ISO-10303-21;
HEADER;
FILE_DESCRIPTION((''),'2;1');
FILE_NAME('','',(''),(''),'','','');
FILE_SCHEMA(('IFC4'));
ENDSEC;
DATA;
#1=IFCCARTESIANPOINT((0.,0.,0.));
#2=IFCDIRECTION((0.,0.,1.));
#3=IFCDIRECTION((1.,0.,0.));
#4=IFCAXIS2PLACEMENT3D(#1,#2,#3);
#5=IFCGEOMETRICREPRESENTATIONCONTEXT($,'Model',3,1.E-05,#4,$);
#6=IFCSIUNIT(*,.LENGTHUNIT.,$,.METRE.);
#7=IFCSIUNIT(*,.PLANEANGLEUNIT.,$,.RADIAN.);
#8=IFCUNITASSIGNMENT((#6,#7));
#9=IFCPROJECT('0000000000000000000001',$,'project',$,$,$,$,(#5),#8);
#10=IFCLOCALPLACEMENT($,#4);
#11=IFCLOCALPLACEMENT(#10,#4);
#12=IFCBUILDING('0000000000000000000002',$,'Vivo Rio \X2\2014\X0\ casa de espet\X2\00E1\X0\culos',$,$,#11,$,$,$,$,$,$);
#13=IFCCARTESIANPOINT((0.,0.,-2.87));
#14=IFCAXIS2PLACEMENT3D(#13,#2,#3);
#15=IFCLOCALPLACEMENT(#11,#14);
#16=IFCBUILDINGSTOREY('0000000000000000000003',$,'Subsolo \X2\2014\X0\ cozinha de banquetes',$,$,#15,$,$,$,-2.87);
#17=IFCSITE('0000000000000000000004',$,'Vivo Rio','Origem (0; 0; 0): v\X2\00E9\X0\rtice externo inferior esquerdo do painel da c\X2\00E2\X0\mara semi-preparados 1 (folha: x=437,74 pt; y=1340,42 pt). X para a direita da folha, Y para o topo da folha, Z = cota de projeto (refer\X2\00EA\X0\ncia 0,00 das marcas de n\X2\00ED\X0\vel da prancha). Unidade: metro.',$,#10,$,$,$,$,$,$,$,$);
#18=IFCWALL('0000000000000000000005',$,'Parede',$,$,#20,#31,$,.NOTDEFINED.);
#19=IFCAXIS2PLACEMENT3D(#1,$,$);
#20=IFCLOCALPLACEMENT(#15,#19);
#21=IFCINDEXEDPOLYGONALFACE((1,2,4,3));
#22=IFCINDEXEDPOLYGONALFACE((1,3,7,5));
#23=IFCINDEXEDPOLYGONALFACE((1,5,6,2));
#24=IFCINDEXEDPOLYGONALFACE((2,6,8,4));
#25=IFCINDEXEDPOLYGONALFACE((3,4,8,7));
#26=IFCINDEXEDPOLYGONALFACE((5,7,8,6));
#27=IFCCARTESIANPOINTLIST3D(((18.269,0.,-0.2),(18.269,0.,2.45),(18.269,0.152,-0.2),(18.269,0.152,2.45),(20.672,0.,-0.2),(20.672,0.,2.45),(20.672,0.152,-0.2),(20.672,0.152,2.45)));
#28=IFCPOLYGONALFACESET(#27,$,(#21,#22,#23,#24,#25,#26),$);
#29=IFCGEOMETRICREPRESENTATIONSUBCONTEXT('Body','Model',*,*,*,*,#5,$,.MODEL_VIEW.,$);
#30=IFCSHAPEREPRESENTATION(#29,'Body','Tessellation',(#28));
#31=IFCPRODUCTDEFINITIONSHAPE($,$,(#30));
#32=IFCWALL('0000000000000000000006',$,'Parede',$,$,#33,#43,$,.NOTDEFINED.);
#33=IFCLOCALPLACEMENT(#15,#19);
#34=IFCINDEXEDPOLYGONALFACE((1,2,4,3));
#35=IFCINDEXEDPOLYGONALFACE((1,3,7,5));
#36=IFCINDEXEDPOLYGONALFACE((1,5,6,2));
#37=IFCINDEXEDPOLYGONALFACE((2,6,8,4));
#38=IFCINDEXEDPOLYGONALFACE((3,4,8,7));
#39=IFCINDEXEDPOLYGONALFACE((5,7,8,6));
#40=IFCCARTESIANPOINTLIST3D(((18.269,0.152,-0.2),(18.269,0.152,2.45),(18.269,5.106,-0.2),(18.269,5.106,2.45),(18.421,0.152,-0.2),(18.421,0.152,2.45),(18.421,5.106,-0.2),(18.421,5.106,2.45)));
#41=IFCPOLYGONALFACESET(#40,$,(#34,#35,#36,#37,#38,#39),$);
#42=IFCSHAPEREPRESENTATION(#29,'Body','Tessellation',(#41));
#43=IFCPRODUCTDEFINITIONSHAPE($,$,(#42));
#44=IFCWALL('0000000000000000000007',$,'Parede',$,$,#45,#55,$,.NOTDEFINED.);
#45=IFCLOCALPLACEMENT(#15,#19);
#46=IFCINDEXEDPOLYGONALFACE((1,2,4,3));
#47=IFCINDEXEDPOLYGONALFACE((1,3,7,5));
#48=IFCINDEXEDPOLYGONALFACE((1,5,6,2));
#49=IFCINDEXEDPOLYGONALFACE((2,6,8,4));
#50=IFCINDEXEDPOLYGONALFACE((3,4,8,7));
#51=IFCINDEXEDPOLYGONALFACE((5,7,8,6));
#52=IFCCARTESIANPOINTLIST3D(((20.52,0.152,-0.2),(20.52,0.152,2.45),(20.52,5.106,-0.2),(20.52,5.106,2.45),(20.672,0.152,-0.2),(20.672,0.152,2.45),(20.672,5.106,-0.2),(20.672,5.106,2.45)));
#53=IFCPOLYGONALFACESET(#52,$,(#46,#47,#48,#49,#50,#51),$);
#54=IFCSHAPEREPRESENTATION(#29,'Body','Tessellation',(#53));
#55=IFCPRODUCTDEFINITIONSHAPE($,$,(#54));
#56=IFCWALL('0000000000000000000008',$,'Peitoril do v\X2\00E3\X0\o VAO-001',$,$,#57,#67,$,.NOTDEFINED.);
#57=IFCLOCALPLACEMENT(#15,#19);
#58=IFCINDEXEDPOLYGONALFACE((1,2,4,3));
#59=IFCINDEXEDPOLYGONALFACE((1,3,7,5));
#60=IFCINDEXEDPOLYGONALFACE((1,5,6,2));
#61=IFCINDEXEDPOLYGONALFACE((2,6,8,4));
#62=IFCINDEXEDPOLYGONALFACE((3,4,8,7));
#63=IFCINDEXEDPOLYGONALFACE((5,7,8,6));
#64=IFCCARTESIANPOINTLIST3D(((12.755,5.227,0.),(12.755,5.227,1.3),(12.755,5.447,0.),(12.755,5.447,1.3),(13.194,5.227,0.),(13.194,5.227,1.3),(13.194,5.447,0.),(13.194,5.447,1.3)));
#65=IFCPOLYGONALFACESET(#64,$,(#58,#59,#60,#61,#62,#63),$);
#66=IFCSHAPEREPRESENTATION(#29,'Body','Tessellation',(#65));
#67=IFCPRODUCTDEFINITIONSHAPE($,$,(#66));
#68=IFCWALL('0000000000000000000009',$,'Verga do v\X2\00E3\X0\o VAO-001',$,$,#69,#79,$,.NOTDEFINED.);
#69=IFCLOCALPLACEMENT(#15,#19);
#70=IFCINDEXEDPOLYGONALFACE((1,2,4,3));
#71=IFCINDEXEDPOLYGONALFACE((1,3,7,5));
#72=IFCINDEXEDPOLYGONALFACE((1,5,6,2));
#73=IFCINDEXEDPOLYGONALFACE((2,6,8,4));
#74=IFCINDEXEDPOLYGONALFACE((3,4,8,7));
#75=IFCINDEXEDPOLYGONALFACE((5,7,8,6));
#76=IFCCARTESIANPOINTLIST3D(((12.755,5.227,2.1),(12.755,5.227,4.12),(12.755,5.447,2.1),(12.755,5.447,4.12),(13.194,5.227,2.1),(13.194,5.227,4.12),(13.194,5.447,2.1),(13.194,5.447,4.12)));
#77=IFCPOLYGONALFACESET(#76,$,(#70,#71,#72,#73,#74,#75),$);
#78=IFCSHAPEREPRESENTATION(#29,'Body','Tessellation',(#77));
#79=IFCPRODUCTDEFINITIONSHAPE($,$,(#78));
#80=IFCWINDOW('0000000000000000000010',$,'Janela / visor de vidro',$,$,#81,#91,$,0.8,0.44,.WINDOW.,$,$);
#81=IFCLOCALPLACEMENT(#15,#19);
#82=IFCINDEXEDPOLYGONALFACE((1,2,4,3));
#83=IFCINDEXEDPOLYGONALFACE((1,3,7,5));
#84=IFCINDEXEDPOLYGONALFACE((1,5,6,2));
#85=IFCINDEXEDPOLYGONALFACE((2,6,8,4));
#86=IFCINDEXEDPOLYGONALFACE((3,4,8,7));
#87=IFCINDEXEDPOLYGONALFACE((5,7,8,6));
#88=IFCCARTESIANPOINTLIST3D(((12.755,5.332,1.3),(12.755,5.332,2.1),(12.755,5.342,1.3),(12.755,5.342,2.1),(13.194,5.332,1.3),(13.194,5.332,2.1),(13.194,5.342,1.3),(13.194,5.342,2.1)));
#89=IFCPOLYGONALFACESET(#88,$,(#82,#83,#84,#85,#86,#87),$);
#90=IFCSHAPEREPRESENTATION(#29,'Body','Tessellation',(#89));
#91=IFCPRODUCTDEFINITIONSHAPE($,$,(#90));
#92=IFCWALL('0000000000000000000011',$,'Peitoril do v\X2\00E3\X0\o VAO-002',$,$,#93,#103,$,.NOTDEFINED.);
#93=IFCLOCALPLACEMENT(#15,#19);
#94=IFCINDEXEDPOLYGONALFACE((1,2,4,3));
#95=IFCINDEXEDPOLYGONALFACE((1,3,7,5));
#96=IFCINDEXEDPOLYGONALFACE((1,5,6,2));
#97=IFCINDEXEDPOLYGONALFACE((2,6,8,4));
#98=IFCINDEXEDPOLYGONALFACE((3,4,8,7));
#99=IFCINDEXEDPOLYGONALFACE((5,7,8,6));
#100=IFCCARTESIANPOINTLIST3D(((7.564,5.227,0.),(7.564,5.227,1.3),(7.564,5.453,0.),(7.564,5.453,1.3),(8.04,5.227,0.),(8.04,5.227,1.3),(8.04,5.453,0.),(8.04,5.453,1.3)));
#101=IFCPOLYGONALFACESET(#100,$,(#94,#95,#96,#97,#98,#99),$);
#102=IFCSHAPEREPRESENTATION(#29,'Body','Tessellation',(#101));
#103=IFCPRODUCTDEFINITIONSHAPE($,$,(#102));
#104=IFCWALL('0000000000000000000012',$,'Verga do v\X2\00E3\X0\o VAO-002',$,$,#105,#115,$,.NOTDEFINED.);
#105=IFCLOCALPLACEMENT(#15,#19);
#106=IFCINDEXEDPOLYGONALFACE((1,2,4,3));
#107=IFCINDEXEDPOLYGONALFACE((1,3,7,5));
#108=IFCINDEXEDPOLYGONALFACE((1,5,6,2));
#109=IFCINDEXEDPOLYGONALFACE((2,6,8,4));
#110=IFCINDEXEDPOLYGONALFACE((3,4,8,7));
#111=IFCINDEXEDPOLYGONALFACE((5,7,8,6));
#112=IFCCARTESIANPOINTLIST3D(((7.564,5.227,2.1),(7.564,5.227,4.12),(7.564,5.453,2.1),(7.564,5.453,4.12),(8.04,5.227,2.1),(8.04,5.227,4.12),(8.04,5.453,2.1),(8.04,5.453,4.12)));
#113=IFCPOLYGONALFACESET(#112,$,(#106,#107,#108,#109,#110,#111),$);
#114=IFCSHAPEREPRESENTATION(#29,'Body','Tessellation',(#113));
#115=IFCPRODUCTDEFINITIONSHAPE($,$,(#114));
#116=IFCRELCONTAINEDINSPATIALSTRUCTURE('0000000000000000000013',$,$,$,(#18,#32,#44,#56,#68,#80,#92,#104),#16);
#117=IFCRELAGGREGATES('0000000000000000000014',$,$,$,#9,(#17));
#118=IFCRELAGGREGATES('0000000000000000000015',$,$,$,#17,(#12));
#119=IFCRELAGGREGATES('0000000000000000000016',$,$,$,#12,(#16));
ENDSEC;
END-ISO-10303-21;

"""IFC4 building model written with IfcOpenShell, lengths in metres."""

from ifc_helpers import new_model, si_unit, frame, origin_with_axes, origin_2d, place, context, subcontext, project, spatial, rectangle, extrude, element, save


model = new_model("IFC4")

# Units and contexts
model_context = context("Model", 3, precision=1e-05, world=origin_with_axes())
body_context = subcontext(model_context, "Body", "Model", "MODEL_VIEW")
ifc_project = project(units=[si_unit("LENGTHUNIT", "METRE"), si_unit("PLANEANGLEUNIT", "RADIAN")], contexts=[model_context])

# Site, building, storey
site_placement = place(None, origin_with_axes())
site = spatial("IfcSite", under=ifc_project, at=site_placement, Name="Vivo Rio", Description="Origem (0; 0; 0): vértice externo inferior esquerdo do painel da câmara semi-preparados 1 (folha: x=437,74 pt; y=1340,42 pt). X para a direita da folha, Y para o topo da folha, Z = cota de projeto (referência 0,00 das marcas de nível da prancha). Unidade: metro.")
building_placement = place(site_placement, origin_with_axes())
building = spatial("IfcBuilding", under=site, at=building_placement, Name="Vivo Rio — casa de espetáculos")
storey_placement = place(building_placement, frame((0.0, 0.0, -2.87), z_axis=(0.0, 0.0, 1.0), x_axis=(1.0, 0.0, 0.0)))
storey = spatial("IfcBuildingStorey", under=building, at=storey_placement, Name="Subsolo — cozinha de banquetes", Elevation=-2.87)

# Walls
wall_1_placement = place(storey_placement, origin_with_axes())
element("IfcWall", 1, at=wall_1_placement, inside=storey, Name="Parede", PredefinedType="NOTDEFINED", context=body_context, shape_type="SweptSolid", body=[
    extrude(rectangle(XDim=2.403, YDim=0.152, at=origin_2d()), frame((19.4705, 0.076, -0.2), z_axis=(0.0, 0.0, 1.0), x_axis=(1.0, 0.0, 0.0)), (0.0, 0.0, 1.0), 2.65),
])
wall_2_placement = place(storey_placement, origin_with_axes())
element("IfcWall", 2, at=wall_2_placement, inside=storey, Name="Parede", PredefinedType="NOTDEFINED", context=body_context, shape_type="SweptSolid", body=[
    extrude(rectangle(XDim=4.954, YDim=0.152, at=origin_2d()), frame((18.345, 2.629, -0.2), z_axis=(0.0, 0.0, 1.0), x_axis=(0.0, -1.0, 0.0)), (0.0, 0.0, 1.0), 2.65),
])
wall_3_placement = place(storey_placement, origin_with_axes())
element("IfcWall", 3, at=wall_3_placement, inside=storey, Name="Parede", PredefinedType="NOTDEFINED", context=body_context, shape_type="SweptSolid", body=[
    extrude(rectangle(XDim=4.954, YDim=0.152, at=origin_2d()), frame((20.596, 2.629, -0.2), z_axis=(0.0, 0.0, 1.0), x_axis=(0.0, -1.0, 0.0)), (0.0, 0.0, 1.0), 2.65),
])
wall_4_placement = place(storey_placement, origin_with_axes())
element("IfcWall", 4, at=wall_4_placement, inside=storey, Name="Peitoril do vão VAO-001", PredefinedType="NOTDEFINED", context=body_context, shape_type="SweptSolid", body=[
    extrude(rectangle(XDim=0.439, YDim=0.22, at=origin_2d()), frame((12.9745, 5.337, 0.0), z_axis=(0.0, 0.0, 1.0), x_axis=(1.0, 0.0, 0.0)), (0.0, 0.0, 1.0), 1.3),
])
wall_5_placement = place(storey_placement, origin_with_axes())
element("IfcWall", 5, at=wall_5_placement, inside=storey, Name="Verga do vão VAO-001", PredefinedType="NOTDEFINED", context=body_context, shape_type="SweptSolid", body=[
    extrude(rectangle(XDim=0.439, YDim=0.22, at=origin_2d()), frame((12.9745, 5.337, 2.1), z_axis=(0.0, 0.0, 1.0), x_axis=(1.0, 0.0, 0.0)), (0.0, 0.0, 1.0), 2.02),
])

# Window
window_placement = place(storey_placement, origin_with_axes())
element("IfcWindow", 6, at=window_placement, inside=storey, Name="Janela / visor de vidro", OverallHeight=0.8, OverallWidth=0.44, PredefinedType="WINDOW", context=body_context, shape_type="SweptSolid", body=[
    extrude(rectangle(XDim=0.439, YDim=0.01, at=origin_2d()), frame((12.9745, 5.337, 1.3), z_axis=(0.0, 0.0, 1.0), x_axis=(1.0, 0.0, 0.0)), (0.0, 0.0, 1.0), 0.8),
])

# Walls
wall_6_placement = place(storey_placement, origin_with_axes())
element("IfcWall", 7, at=wall_6_placement, inside=storey, Name="Peitoril do vão VAO-002", PredefinedType="NOTDEFINED", context=body_context, shape_type="SweptSolid", body=[
    extrude(rectangle(XDim=0.476, YDim=0.226, at=origin_2d()), frame((7.802, 5.34, 0.0), z_axis=(0.0, 0.0, 1.0), x_axis=(1.0, 0.0, 0.0)), (0.0, 0.0, 1.0), 1.3),
])
wall_7_placement = place(storey_placement, origin_with_axes())
element("IfcWall", 8, at=wall_7_placement, inside=storey, Name="Verga do vão VAO-002", PredefinedType="NOTDEFINED", context=body_context, shape_type="SweptSolid", body=[
    extrude(rectangle(XDim=0.476, YDim=0.226, at=origin_2d()), frame((7.802, 5.34, 2.1), z_axis=(0.0, 0.0, 1.0), x_axis=(1.0, 0.0, 0.0)), (0.0, 0.0, 1.0), 2.02),
])

save(model, "model.ifc")
